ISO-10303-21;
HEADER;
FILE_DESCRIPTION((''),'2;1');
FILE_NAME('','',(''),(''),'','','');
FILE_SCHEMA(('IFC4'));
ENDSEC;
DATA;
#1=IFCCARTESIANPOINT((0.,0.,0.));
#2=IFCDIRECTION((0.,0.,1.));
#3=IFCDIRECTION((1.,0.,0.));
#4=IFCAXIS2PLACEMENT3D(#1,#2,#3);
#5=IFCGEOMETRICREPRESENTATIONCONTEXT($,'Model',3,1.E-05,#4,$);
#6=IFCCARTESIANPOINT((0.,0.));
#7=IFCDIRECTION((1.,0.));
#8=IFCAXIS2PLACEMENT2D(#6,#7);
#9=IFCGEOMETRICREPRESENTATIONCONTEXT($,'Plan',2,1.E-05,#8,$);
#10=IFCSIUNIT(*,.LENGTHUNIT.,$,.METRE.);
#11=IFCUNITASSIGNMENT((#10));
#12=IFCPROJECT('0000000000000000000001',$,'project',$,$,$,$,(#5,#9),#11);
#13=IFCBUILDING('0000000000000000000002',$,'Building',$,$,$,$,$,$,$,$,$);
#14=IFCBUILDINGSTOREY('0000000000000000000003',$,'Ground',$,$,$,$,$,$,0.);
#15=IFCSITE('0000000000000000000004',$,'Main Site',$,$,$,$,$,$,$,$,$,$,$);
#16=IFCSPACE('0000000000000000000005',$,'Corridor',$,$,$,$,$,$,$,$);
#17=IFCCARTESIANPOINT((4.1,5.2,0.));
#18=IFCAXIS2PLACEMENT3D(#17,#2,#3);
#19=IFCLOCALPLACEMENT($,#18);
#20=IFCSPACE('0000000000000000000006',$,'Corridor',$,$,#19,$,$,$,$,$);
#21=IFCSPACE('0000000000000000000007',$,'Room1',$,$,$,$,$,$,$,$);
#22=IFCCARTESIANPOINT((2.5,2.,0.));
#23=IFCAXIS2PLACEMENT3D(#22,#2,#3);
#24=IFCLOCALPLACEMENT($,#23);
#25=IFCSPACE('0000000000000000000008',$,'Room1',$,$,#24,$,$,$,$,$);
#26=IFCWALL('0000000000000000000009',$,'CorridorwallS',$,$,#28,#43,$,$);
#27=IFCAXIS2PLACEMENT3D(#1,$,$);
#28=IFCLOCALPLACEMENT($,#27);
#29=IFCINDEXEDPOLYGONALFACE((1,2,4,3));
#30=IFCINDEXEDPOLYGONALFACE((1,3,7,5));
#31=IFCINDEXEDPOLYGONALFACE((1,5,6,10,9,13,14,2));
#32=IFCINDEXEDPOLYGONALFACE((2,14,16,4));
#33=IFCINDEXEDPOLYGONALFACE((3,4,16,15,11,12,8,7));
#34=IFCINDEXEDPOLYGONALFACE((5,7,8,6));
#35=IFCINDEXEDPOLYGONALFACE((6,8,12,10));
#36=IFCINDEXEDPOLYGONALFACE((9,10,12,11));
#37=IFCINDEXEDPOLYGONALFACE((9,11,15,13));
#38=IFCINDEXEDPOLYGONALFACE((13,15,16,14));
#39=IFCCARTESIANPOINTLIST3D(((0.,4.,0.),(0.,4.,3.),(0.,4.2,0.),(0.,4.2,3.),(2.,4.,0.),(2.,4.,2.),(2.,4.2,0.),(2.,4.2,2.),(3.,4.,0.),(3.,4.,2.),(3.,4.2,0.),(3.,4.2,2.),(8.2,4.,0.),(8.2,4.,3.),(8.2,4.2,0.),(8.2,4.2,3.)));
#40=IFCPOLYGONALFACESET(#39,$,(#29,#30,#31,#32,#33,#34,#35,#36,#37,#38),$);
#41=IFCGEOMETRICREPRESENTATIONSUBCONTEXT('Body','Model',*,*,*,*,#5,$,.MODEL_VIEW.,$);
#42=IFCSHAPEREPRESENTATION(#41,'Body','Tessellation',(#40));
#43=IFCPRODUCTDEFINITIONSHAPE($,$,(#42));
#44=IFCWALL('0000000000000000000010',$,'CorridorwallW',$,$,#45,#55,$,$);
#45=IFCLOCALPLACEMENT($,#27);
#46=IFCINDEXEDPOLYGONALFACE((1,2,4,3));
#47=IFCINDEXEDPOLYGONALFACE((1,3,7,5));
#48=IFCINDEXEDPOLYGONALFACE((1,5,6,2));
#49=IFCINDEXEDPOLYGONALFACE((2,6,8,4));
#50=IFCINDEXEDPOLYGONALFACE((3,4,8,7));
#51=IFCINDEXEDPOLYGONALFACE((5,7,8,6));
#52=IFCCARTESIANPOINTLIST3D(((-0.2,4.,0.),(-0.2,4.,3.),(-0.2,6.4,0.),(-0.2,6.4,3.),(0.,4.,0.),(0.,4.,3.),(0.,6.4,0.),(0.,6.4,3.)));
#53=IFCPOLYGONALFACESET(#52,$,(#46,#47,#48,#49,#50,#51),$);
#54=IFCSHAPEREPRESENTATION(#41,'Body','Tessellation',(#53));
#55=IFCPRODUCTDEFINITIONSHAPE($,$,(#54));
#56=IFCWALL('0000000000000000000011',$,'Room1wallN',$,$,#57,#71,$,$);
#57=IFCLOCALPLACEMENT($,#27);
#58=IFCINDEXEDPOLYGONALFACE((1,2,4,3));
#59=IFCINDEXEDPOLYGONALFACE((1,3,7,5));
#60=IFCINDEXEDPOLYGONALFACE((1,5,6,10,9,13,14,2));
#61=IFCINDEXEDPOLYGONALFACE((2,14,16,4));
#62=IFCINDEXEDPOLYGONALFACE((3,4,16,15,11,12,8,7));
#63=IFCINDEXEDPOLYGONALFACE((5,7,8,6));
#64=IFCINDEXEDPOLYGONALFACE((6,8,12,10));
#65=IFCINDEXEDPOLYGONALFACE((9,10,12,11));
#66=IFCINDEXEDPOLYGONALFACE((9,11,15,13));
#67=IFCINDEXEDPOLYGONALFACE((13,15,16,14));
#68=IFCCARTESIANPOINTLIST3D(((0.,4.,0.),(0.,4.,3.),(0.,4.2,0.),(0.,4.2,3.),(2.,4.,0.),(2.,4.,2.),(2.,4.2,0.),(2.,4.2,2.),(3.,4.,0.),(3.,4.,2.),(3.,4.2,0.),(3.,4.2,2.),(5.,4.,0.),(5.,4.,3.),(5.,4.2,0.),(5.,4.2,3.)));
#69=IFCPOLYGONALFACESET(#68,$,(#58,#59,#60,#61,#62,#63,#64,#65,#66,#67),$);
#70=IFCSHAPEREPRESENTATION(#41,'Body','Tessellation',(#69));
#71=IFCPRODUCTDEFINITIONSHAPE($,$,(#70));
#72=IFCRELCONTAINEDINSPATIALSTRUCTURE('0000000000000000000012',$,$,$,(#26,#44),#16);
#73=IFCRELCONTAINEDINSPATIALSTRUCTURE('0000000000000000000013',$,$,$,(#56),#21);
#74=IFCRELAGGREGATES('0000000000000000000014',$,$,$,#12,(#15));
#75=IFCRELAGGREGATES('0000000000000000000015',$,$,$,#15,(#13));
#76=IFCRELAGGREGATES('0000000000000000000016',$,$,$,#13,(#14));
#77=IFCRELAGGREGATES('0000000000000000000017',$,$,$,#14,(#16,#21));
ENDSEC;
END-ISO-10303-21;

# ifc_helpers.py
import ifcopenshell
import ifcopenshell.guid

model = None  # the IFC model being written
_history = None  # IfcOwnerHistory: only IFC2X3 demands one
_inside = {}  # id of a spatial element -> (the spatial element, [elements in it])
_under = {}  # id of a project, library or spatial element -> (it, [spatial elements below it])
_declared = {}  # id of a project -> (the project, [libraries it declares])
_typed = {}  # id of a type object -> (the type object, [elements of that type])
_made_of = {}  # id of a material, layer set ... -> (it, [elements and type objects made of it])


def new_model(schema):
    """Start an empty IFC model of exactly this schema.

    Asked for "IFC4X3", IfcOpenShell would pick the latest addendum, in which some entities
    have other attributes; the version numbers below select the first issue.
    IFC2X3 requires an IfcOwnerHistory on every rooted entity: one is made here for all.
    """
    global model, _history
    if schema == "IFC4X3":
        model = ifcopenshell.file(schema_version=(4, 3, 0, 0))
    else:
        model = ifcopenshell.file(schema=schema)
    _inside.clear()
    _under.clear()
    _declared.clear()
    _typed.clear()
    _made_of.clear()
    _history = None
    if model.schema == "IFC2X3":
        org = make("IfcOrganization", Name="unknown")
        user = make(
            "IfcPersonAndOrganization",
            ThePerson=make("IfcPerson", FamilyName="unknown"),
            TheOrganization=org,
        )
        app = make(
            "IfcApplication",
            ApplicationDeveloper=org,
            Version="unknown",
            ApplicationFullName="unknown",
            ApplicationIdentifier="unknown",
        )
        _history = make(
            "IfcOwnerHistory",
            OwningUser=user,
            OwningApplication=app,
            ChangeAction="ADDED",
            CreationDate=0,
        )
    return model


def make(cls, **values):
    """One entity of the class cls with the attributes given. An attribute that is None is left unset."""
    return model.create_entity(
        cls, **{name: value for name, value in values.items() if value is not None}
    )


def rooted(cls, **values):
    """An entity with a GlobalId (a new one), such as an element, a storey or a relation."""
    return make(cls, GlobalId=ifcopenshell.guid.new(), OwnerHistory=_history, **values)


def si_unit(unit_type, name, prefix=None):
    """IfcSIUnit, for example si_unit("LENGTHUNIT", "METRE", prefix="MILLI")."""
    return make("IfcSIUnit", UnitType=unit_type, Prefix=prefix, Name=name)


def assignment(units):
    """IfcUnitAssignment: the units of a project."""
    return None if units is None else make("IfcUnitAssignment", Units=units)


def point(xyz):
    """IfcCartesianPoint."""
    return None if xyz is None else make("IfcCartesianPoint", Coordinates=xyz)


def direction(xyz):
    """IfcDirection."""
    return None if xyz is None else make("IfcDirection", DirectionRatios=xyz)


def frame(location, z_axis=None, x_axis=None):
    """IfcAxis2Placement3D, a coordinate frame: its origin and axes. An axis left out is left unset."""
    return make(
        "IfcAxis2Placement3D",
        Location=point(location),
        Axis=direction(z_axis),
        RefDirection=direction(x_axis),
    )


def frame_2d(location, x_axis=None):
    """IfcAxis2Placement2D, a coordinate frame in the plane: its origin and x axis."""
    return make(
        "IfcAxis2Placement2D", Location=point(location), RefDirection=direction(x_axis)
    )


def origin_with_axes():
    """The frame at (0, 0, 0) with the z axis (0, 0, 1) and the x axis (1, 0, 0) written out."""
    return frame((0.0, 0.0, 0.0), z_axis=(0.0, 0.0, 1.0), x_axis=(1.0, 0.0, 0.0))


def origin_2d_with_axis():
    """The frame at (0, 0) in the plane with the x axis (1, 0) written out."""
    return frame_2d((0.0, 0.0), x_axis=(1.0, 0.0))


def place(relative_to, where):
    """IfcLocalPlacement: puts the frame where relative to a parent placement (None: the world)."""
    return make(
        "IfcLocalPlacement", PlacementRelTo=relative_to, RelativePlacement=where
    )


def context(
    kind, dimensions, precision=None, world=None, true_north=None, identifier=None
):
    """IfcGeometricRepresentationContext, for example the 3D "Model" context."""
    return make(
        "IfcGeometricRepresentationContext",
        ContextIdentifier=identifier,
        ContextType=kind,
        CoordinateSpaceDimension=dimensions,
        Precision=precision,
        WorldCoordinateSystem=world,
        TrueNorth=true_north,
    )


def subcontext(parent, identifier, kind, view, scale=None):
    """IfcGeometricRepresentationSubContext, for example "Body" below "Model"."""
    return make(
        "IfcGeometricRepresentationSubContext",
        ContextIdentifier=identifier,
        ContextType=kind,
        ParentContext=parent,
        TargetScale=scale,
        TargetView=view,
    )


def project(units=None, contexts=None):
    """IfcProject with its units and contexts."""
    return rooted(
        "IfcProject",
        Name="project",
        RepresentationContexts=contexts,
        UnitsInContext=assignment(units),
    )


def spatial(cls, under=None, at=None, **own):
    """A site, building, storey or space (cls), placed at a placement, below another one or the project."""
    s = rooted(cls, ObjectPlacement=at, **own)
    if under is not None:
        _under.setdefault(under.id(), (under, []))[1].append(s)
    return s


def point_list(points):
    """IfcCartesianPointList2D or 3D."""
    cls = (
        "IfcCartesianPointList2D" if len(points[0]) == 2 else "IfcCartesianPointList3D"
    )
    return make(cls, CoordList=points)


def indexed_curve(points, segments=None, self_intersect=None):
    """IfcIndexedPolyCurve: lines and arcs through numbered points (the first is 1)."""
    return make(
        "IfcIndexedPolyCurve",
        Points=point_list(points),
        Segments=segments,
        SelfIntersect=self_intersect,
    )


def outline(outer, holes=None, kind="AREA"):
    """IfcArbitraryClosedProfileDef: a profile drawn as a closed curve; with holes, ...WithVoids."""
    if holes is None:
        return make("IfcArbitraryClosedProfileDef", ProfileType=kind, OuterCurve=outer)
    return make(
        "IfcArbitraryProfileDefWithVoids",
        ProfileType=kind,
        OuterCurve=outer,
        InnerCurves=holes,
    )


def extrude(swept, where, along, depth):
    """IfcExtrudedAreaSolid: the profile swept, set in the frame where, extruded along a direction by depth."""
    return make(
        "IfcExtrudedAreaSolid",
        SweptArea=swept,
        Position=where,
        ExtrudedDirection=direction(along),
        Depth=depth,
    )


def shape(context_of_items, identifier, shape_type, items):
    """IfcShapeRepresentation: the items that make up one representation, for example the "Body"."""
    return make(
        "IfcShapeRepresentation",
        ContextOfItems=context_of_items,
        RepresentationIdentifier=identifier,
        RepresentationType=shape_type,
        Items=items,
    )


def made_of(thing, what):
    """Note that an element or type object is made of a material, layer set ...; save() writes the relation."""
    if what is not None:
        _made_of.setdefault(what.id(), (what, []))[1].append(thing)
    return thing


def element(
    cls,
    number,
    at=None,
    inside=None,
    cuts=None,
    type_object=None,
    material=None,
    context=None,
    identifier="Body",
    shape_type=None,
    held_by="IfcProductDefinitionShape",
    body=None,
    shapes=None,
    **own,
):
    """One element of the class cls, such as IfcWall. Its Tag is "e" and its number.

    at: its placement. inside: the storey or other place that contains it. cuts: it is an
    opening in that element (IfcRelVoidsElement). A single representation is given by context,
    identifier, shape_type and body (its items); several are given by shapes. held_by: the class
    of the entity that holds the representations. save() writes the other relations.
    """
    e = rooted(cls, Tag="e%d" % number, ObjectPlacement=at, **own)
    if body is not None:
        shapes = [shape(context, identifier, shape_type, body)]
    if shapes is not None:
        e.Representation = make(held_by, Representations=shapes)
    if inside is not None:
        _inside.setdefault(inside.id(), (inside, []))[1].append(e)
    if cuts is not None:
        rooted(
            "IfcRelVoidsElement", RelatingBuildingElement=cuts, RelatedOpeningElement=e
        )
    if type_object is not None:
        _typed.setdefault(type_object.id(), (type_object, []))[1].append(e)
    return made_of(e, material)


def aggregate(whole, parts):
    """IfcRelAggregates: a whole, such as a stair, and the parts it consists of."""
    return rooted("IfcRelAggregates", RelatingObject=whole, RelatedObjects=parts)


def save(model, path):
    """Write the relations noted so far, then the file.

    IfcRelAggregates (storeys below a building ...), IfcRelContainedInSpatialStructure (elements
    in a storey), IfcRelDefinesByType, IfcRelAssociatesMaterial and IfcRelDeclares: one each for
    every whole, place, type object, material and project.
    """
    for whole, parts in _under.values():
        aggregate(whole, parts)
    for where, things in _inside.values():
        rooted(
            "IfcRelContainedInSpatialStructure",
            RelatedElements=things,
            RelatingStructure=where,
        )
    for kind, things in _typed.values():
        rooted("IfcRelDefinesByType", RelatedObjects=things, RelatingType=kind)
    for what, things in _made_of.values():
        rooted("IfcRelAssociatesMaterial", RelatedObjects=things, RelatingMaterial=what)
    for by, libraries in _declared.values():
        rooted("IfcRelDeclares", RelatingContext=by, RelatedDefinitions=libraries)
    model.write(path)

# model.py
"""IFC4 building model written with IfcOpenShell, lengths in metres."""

from ifc_helpers import new_model, si_unit, frame, origin_with_axes, origin_2d_with_axis, place, context, subcontext, project, spatial, indexed_curve, outline, extrude, element, save


model = new_model("IFC4")

# Units and contexts
model_context = context("Model", 3, precision=1e-05, world=origin_with_axes())
plan_context = context("Plan", 2, precision=1e-05, world=origin_2d_with_axis())
body_context = subcontext(model_context, "Body", "Model", "MODEL_VIEW")
ifc_project = project(units=[si_unit("LENGTHUNIT", "METRE")], contexts=[model_context, plan_context])

# Site, building, storey, space
site = spatial("IfcSite", under=ifc_project, Name="Main Site")
building = spatial("IfcBuilding", under=site, Name="Building")
storey = spatial("IfcBuildingStorey", under=building, Name="Ground", Elevation=0.0)
space_1 = spatial("IfcSpace", under=storey, Name="Corridor")

# Wall
wall_1_placement = place(None, frame((0.0, 4.0, 0.0), z_axis=(0.0, 0.0, 1.0), x_axis=(1.0, 0.0, 0.0)))
wall_1 = element("IfcWall", 1, at=wall_1_placement, inside=space_1, Name="CorridorwallS", context=body_context, shape_type="SweptSolid", body=[
    extrude(outline(indexed_curve([(0.0, 0.0), (0.0, 0.2), (8.2, 0.2), (8.2, 0.0), (0.0, 0.0)], self_intersect=False)), origin_with_axes(), (0.0, 0.0, 1.0), 3.0),
])

# Shared definitions
space_2_placement = place(None, frame((4.1, 5.2, 0.0), z_axis=(0.0, 0.0, 1.0), x_axis=(1.0, 0.0, 0.0)))
space_2 = spatial("IfcSpace", at=space_2_placement, Name="Corridor")

# Opening
opening_1_placement = place(wall_1_placement, frame((2.0, 0.0, 0.0), z_axis=(0.0, 0.0, 1.0), x_axis=(1.0, 0.0, 0.0)))
element("IfcOpeningElement", 2, at=opening_1_placement, inside=space_2, cuts=wall_1, context=body_context, shape_type="SweptSolid", body=[
    extrude(outline(indexed_curve([(0.0, 0.0), (0.0, 0.4), (1.0, 0.4), (1.0, 0.0), (0.0, 0.0)], self_intersect=False)), origin_with_axes(), (0.0, 0.0, 1.0), 2.0),
])

# Wall
wall_2_placement = place(None, frame((0.0, 4.0, 0.0), z_axis=(0.0, 0.0, 1.0), x_axis=(0.0, 1.0, 0.0)))
element("IfcWall", 3, at=wall_2_placement, inside=space_1, Name="CorridorwallW", context=body_context, shape_type="SweptSolid", body=[
    extrude(outline(indexed_curve([(0.0, 0.0), (0.0, 0.2), (2.4, 0.2), (2.4, 0.0), (0.0, 0.0)], self_intersect=False)), origin_with_axes(), (0.0, 0.0, 1.0), 3.0),
])

# Shared definitions
space_3 = spatial("IfcSpace", under=storey, Name="Room1")

# Wall
wall_3_placement = place(None, frame((0.0, 4.0, 0.0), z_axis=(0.0, 0.0, 1.0), x_axis=(1.0, 0.0, 0.0)))
wall_3 = element("IfcWall", 4, at=wall_3_placement, inside=space_3, Name="Room1wallN", context=body_context, shape_type="SweptSolid", body=[
    extrude(outline(indexed_curve([(0.0, 0.0), (0.0, 0.2), (5.0, 0.2), (5.0, 0.0), (0.0, 0.0)], self_intersect=False)), origin_with_axes(), (0.0, 0.0, 1.0), 3.0),
])

# Shared definitions
space_4_placement = place(None, frame((2.5, 2.0, 0.0), z_axis=(0.0, 0.0, 1.0), x_axis=(1.0, 0.0, 0.0)))
space_4 = spatial("IfcSpace", at=space_4_placement, Name="Room1")

# Opening
opening_2_placement = place(wall_3_placement, frame((2.0, 0.0, 0.0), z_axis=(0.0, 0.0, 1.0), x_axis=(1.0, 0.0, 0.0)))
element("IfcOpeningElement", 5, at=opening_2_placement, inside=space_4, cuts=wall_3, context=body_context, shape_type="SweptSolid", body=[
    extrude(outline(indexed_curve([(0.0, 0.0), (0.0, 0.4), (1.0, 0.4), (1.0, 0.0), (0.0, 0.0)], self_intersect=False)), origin_with_axes(), (0.0, 0.0, 1.0), 2.0),
])

save(model, "model.ifc")
